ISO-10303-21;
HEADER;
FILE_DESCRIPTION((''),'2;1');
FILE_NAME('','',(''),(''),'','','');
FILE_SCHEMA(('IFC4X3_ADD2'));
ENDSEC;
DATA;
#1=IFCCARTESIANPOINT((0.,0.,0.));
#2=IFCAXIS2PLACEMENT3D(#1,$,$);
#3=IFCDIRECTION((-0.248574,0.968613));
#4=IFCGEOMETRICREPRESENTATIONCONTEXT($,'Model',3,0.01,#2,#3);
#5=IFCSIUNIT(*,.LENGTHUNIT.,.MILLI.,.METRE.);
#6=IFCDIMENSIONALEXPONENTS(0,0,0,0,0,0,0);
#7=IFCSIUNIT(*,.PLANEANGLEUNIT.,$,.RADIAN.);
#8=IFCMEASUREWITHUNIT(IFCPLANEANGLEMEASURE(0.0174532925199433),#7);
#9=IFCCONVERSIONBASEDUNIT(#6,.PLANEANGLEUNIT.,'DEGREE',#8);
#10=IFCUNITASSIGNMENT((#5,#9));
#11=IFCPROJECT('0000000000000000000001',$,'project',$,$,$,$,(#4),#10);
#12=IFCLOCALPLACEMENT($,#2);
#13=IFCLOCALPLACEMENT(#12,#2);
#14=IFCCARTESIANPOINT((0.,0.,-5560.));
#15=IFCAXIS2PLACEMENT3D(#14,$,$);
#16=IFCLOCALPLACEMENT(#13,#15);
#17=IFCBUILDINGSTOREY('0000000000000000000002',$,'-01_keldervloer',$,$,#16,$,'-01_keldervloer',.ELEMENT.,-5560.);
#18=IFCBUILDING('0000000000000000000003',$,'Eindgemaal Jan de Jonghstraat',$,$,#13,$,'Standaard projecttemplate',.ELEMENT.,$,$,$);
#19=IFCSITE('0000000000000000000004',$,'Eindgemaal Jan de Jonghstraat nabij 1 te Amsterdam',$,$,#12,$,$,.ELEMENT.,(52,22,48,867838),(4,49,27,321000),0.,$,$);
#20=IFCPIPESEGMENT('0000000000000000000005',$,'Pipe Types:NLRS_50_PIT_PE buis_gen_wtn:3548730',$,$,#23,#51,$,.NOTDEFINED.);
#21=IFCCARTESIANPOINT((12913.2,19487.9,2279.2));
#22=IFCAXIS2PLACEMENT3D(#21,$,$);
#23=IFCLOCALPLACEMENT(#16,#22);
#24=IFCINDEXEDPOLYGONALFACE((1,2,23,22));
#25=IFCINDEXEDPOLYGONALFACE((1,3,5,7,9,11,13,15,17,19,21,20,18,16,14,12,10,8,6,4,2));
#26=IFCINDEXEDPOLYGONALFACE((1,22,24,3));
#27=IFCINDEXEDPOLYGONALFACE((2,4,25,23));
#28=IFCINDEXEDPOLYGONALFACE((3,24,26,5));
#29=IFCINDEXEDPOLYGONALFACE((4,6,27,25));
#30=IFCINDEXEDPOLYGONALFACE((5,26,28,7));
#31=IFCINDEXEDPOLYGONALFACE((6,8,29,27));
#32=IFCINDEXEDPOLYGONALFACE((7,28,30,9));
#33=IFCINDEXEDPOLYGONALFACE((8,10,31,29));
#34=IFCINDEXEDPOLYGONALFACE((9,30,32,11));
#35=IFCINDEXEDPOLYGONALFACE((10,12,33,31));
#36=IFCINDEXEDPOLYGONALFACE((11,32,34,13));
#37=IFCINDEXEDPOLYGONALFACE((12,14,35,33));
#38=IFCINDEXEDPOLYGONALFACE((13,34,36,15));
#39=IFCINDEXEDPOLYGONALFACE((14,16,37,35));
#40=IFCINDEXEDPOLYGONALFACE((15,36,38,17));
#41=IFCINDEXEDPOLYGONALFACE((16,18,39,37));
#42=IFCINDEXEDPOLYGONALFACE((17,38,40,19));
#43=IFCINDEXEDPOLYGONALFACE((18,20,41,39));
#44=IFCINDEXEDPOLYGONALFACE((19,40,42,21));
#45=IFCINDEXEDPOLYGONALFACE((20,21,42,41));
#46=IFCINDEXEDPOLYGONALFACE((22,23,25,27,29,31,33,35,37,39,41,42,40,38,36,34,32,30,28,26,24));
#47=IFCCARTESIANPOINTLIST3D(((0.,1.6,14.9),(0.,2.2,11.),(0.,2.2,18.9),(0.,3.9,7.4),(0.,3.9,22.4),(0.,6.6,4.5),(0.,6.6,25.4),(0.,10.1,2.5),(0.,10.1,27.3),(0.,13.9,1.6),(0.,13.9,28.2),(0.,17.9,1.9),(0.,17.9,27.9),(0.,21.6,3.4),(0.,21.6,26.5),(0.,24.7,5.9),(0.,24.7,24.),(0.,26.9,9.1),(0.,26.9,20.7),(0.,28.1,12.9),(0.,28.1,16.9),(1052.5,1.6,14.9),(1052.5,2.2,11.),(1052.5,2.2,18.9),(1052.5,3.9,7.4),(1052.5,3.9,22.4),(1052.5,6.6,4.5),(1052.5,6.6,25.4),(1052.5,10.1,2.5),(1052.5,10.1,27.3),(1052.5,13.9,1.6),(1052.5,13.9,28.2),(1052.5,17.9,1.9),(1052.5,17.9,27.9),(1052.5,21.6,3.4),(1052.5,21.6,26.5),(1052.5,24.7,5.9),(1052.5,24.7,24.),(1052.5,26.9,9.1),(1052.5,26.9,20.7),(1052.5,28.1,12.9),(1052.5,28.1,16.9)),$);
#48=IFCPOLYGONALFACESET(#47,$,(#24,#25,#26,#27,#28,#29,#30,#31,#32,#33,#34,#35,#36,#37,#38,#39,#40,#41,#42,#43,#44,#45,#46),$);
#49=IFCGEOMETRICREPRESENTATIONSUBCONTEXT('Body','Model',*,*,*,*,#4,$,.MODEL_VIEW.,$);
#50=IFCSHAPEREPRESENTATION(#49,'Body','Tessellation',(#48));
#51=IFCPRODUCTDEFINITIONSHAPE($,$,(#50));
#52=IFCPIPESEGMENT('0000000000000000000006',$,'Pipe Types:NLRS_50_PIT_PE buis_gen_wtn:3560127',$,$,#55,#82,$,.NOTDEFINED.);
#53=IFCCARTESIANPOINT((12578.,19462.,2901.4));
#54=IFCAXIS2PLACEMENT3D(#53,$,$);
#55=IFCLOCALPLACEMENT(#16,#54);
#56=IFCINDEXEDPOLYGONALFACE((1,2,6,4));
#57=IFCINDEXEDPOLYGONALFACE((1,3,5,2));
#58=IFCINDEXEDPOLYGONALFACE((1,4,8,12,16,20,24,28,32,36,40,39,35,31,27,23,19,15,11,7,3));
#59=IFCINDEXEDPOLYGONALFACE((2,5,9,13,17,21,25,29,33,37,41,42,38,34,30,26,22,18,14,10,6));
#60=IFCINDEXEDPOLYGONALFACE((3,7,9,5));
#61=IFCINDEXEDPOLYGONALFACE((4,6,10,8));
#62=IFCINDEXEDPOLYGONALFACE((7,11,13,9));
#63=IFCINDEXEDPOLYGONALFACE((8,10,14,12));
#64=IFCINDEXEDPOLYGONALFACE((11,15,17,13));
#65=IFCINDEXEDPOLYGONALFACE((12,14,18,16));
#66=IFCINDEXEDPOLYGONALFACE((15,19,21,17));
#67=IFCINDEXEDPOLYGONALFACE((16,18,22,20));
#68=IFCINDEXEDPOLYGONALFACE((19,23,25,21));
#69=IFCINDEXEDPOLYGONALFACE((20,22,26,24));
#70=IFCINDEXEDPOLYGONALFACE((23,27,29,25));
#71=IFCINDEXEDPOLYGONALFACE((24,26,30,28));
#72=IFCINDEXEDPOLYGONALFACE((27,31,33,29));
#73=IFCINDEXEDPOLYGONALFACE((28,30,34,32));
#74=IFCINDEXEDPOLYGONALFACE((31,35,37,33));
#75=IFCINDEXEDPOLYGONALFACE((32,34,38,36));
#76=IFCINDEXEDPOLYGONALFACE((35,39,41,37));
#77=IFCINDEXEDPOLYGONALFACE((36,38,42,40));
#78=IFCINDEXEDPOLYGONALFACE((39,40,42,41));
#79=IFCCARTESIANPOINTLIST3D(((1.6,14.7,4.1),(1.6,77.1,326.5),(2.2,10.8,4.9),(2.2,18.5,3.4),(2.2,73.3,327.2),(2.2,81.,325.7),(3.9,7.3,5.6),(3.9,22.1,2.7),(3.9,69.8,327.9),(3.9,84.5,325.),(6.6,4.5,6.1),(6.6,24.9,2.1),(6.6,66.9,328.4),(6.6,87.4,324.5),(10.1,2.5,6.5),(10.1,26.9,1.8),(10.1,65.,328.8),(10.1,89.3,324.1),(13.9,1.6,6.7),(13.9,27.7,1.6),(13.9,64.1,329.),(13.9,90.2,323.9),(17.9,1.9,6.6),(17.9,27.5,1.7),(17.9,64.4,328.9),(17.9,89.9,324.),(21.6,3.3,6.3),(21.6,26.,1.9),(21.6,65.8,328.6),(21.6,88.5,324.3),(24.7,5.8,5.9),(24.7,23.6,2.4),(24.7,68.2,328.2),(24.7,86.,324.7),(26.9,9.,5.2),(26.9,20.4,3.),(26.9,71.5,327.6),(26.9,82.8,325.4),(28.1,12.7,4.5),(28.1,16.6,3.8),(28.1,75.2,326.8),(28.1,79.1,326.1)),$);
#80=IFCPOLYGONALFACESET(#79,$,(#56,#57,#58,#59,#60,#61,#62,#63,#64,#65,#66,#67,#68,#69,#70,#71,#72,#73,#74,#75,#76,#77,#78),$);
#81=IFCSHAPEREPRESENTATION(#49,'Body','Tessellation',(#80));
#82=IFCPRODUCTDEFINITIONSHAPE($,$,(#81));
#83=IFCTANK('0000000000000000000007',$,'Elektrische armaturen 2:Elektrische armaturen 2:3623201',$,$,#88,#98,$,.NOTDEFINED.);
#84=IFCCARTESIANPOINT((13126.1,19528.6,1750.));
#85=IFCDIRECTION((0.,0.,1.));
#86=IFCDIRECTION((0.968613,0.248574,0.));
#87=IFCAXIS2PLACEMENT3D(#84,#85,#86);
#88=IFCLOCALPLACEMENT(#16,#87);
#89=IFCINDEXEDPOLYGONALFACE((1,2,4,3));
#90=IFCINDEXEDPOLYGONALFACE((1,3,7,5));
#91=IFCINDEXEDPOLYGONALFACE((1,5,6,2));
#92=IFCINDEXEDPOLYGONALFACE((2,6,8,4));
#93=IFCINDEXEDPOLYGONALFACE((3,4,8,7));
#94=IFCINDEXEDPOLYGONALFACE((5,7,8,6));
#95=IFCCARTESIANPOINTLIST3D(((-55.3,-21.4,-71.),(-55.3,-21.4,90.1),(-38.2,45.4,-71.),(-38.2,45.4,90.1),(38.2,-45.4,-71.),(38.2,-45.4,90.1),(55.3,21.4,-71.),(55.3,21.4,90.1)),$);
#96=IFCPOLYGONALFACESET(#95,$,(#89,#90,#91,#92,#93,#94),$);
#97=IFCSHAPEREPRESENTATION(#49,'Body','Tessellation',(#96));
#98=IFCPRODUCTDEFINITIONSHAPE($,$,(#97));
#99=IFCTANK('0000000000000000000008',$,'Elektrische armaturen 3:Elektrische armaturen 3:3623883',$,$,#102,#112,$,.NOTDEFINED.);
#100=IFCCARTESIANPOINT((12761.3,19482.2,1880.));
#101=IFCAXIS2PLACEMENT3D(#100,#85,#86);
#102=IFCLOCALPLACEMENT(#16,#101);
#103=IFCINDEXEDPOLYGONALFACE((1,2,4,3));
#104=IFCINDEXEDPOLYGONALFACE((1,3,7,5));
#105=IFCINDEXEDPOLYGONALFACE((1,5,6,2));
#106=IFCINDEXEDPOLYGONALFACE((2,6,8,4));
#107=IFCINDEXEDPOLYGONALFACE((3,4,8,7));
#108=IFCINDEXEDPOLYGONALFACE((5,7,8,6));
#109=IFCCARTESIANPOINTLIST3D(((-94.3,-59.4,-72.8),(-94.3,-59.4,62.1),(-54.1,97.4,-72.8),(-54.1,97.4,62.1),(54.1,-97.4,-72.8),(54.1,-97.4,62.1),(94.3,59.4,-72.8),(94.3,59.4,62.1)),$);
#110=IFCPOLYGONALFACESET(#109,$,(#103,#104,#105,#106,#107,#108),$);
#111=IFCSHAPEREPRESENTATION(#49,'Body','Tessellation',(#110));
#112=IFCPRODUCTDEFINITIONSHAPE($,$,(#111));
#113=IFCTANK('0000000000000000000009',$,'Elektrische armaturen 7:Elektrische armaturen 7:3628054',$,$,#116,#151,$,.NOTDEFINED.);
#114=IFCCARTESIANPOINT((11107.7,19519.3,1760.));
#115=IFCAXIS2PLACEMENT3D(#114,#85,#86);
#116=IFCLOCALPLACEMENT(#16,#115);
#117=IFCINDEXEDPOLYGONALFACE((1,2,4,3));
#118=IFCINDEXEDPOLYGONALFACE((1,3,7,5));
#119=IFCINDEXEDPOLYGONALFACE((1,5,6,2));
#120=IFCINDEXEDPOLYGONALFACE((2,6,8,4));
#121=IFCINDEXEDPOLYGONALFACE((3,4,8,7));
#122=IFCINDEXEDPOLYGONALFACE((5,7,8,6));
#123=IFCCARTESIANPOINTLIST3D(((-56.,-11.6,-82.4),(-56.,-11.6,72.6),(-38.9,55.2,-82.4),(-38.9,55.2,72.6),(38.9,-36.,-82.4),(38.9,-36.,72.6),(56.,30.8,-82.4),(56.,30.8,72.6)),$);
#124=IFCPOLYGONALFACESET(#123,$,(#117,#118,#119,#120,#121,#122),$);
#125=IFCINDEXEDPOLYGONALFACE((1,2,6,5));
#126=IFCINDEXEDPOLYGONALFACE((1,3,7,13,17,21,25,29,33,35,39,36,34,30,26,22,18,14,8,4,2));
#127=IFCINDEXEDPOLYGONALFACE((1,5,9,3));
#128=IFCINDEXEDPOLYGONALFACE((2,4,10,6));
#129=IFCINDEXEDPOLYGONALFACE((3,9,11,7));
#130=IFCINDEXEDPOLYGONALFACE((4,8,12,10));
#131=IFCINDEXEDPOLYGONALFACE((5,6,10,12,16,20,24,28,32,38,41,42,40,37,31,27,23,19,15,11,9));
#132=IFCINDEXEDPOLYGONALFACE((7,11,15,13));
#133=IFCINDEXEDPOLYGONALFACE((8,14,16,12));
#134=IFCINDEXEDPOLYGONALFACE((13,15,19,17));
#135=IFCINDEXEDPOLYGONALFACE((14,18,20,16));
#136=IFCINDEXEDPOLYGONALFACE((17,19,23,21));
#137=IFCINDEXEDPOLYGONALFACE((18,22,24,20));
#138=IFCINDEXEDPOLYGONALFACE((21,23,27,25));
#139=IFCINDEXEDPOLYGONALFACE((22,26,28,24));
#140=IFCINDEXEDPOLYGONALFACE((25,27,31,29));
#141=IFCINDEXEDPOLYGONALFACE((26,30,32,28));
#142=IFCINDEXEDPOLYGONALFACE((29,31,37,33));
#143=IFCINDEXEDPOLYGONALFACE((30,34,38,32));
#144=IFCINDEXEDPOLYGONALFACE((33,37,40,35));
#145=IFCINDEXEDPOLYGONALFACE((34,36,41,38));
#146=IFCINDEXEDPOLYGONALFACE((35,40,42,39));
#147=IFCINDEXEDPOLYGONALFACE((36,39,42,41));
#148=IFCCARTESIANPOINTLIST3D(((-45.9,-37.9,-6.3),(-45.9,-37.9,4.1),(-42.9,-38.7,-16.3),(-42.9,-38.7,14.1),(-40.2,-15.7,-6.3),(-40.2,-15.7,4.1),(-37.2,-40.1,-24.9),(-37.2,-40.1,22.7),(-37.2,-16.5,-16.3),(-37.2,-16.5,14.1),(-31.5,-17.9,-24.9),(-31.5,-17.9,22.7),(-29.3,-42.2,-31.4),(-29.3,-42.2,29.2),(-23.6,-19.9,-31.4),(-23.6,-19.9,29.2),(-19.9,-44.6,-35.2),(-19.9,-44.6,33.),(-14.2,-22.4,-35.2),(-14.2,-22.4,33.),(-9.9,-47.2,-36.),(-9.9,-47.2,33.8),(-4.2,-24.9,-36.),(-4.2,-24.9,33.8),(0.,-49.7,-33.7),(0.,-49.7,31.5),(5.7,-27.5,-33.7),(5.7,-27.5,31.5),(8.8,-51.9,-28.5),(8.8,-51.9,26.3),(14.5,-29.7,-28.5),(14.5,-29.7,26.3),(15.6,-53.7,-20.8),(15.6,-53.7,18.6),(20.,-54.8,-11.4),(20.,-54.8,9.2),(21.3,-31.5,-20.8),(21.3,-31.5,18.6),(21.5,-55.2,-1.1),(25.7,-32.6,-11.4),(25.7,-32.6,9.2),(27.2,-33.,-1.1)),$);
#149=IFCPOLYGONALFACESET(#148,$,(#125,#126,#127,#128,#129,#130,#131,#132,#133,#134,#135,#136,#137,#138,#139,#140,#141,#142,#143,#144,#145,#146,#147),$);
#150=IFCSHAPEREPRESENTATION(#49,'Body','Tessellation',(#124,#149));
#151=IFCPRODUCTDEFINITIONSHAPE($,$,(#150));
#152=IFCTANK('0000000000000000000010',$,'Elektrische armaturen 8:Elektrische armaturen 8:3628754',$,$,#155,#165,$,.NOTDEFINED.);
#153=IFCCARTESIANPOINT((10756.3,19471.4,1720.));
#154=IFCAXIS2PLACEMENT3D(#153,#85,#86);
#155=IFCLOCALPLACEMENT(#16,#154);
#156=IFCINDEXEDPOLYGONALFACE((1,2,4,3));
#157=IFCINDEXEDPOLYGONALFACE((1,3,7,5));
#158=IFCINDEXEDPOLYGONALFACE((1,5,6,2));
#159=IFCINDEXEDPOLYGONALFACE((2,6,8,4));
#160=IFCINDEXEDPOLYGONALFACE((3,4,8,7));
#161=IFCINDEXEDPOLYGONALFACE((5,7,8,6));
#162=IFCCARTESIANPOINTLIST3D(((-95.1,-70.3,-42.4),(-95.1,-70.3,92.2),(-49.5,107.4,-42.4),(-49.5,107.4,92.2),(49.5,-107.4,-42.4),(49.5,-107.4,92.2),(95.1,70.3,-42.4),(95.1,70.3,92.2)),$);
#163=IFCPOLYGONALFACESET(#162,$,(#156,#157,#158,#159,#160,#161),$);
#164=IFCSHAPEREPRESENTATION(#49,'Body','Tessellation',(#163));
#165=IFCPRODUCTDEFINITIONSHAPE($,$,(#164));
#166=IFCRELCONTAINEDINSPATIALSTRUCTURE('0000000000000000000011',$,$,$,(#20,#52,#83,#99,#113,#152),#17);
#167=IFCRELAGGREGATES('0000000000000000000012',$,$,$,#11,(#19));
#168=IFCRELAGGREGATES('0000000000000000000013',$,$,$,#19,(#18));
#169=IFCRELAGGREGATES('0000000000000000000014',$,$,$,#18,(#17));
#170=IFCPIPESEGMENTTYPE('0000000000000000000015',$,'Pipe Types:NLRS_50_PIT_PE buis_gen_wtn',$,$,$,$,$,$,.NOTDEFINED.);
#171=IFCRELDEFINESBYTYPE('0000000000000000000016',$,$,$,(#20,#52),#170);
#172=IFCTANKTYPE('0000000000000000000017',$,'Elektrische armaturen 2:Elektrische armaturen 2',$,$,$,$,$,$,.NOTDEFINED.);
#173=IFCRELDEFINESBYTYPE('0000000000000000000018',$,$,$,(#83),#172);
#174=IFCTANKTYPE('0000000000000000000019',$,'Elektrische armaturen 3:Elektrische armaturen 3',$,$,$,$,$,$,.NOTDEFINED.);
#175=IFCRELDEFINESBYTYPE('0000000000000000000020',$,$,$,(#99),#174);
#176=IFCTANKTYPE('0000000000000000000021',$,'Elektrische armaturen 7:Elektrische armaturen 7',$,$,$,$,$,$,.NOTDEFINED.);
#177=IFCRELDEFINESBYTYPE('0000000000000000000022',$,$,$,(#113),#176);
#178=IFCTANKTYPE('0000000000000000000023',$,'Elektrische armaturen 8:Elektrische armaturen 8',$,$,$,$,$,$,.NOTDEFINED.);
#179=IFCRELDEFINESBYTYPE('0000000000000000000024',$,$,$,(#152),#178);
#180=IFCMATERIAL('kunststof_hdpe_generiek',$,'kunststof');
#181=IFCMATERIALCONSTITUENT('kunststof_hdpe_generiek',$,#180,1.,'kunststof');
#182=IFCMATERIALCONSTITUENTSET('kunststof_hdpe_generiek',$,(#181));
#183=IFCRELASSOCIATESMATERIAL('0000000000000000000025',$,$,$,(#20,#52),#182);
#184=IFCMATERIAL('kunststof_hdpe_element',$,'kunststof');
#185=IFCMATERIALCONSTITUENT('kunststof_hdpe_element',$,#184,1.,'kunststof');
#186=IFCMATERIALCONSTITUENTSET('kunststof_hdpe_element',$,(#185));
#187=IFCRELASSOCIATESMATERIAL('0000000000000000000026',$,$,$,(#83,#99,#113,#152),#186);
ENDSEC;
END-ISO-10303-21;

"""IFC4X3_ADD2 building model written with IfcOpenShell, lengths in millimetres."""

from ifc_helpers import new_model, entity, si_unit, converted_unit, direction, frame, frame_2d, origin, origin_2d_with_axis, place, context, subcontext, project, spatial, rectangle, circle, extrude, source, transform, mapped, material, constituent, constituent_set, type_object, type_shapes, element, save


model = new_model("IFC4X3_ADD2")

# Units and contexts
model_context = context("Model", 3, precision=0.01, world=origin(), true_north=direction((-0.248574, 0.968613)))
body_context = subcontext(model_context, "Body", "Model", "MODEL_VIEW")
ifc_project = project(units=[si_unit("LENGTHUNIT", "METRE", prefix="MILLI"), converted_unit("PLANEANGLEUNIT", "DEGREE", entity("IfcPlaneAngleMeasure", 0.0174532925199433), si_unit("PLANEANGLEUNIT", "RADIAN"), dimensions=[0, 0, 0, 0, 0, 0, 0])], contexts=[model_context])

# Site, building, storey
site_placement = place(None, origin())
site = spatial("IfcSite", under=ifc_project, at=site_placement, Name="Eindgemaal Jan de Jonghstraat nabij 1 te Amsterdam", CompositionType="ELEMENT", RefLatitude=(52, 22, 48, 867838), RefLongitude=(4, 49, 27, 321000), RefElevation=0.0)
building_placement = place(site_placement, origin())
building = spatial("IfcBuilding", under=site, at=building_placement, Name="Eindgemaal Jan de Jonghstraat", LongName="Standaard projecttemplate", CompositionType="ELEMENT")
storey_placement = place(building_placement, frame((0.0, 0.0, -5560.0)))
storey = spatial("IfcBuildingStorey", under=building, at=storey_placement, Name="-01_keldervloer", LongName="-01_keldervloer", CompositionType="ELEMENT", Elevation=-5560.0)

# Pipe segments
ifc_material_1 = material(Name="kunststof_hdpe_generiek", Category="kunststof")
ifc_constituent_1 = constituent(ifc_material_1, Name="kunststof_hdpe_generiek", Category="kunststof", fraction=1.0)
ifc_constituent_set_1 = constituent_set(constituents=[ifc_constituent_1], Name="kunststof_hdpe_generiek")
pipe_segment_type_1 = type_object("IfcPipeSegmentType", Name="Pipe Types:NLRS_50_PIT_PE buis_gen_wtn", PredefinedType="NOTDEFINED")
pipe_segment_1_placement = place(storey_placement, frame((12913.2, 19487.9, 2279.2)))
element("IfcPipeSegment", 1, at=pipe_segment_1_placement, inside=storey, type_object=pipe_segment_type_1, material=ifc_constituent_set_1, Name="Pipe Types:NLRS_50_PIT_PE buis_gen_wtn:3548730", PredefinedType="NOTDEFINED", context=body_context, shape_type="SweptSolid", body=[
    extrude(circle(Radius=13.3, at=origin_2d_with_axis()), frame((0.0, 14.9, 14.9), z_axis=(1.0, 0.0, 0.0), x_axis=(0.0, -1.0, 0.0)), (0.0, 0.0, 1.0), 1052.5),
])
pipe_segment_2_placement = place(storey_placement, frame((12578.0, 19462.0, 2901.4)))
element("IfcPipeSegment", 2, at=pipe_segment_2_placement, inside=storey, type_object=pipe_segment_type_1, material=ifc_constituent_set_1, Name="Pipe Types:NLRS_50_PIT_PE buis_gen_wtn:3560127", PredefinedType="NOTDEFINED", context=body_context, shape_type="SweptSolid", body=[
    extrude(circle(Radius=13.3, at=frame_2d((0.0, 0.0), x_axis=(1.0, 0.0))), frame((14.9, 14.7, 4.1), z_axis=(0.0, 0.190233, 0.981739), x_axis=(-1.0, 0.0, 0.0)), (0.0, 0.0, 1.0), 328.3),
])

# Tanks
ifc_material_2 = material(Name="kunststof_hdpe_element", Category="kunststof")
ifc_constituent_2 = constituent(ifc_material_2, Name="kunststof_hdpe_element", Category="kunststof", fraction=1.0)
ifc_constituent_set_2 = constituent_set(constituents=[ifc_constituent_2], Name="kunststof_hdpe_element")
tank_type_1 = type_object("IfcTankType", Name="Elektrische armaturen 2:Elektrische armaturen 2", PredefinedType="NOTDEFINED")
shared_shape_1 = source(origin(), body_context, "Body", "SweptSolid", [
    extrude(rectangle(XDim=69.0, YDim=96.6, at=origin_2d_with_axis()), frame((0.0, 0.0, -71.0), z_axis=(0.0, 0.0, 1.0), x_axis=(0.248574, 0.968613, 0.0)), (0.0, 0.0, 1.0), 161.1),
])
type_shapes(tank_type_1, [shared_shape_1])
tank_1_placement = place(storey_placement, frame((13126.1, 19528.6, 1750.0), z_axis=(0.0, 0.0, 1.0), x_axis=(0.968613, 0.248574, 0.0)))
element("IfcTank", 3, at=tank_1_placement, inside=storey, type_object=tank_type_1, material=ifc_constituent_set_2, Name="Elektrische armaturen 2:Elektrische armaturen 2:3623201", PredefinedType="NOTDEFINED", context=body_context, shape_type="MappedRepresentation", body=[
    mapped(shared_shape_1, transform((0.0, 0.0, 0.0), scale=1.0)),
])
tank_type_2 = type_object("IfcTankType", Name="Elektrische armaturen 3:Elektrische armaturen 3", PredefinedType="NOTDEFINED")
shared_shape_2 = source(origin(), body_context, "Body", "SweptSolid", [
    extrude(rectangle(XDim=161.9, YDim=153.2, at=origin_2d_with_axis()), frame((0.0, 0.0, -72.8), z_axis=(0.0, 0.0, 1.0), x_axis=(0.248574, 0.968613, 0.0)), (0.0, 0.0, 1.0), 134.9),
])
type_shapes(tank_type_2, [shared_shape_2])
tank_2_placement = place(storey_placement, frame((12761.3, 19482.2, 1880.0), z_axis=(0.0, 0.0, 1.0), x_axis=(0.968613, 0.248574, 0.0)))
element("IfcTank", 4, at=tank_2_placement, inside=storey, type_object=tank_type_2, material=ifc_constituent_set_2, Name="Elektrische armaturen 3:Elektrische armaturen 3:3623883", PredefinedType="NOTDEFINED", context=body_context, shape_type="MappedRepresentation", body=[
    mapped(shared_shape_2, transform((0.0, 0.0, 0.0), scale=1.0)),
])
tank_type_3 = type_object("IfcTankType", Name="Elektrische armaturen 7:Elektrische armaturen 7", PredefinedType="NOTDEFINED")
shared_shape_3 = source(origin(), body_context, "Body", "SweptSolid", [
    extrude(rectangle(XDim=69.0, YDim=98.0, at=frame_2d((0.0, 0.0), x_axis=(1.0, 0.0))), frame((0.0, 9.6, -82.4), z_axis=(0.0, 0.0, 1.0), x_axis=(0.248574, 0.968613, 0.0)), (0.0, 0.0, 1.0), 155.0),
    extrude(circle(Radius=35.0, at=frame_2d((0.0, 0.0), x_axis=(1.0, 0.0))), frame((-12.4, -46.5, -1.1), z_axis=(0.248574, 0.968613, 0.0), x_axis=(0.968613, -0.248574, 0.0)), (0.0, 0.0, 1.0), 22.9),
])
type_shapes(tank_type_3, [shared_shape_3])
tank_3_placement = place(storey_placement, frame((11107.7, 19519.3, 1760.0), z_axis=(0.0, 0.0, 1.0), x_axis=(0.968613, 0.248574, 0.0)))
element("IfcTank", 5, at=tank_3_placement, inside=storey, type_object=tank_type_3, material=ifc_constituent_set_2, Name="Elektrische armaturen 7:Elektrische armaturen 7:3628054", PredefinedType="NOTDEFINED", context=body_context, shape_type="MappedRepresentation", body=[
    mapped(shared_shape_3, transform((0.0, 0.0, 0.0), scale=1.0)),
])
tank_type_4 = type_object("IfcTankType", Name="Elektrische armaturen 8:Elektrische armaturen 8", PredefinedType="NOTDEFINED")
shared_shape_4 = source(origin(), body_context, "Body", "SweptSolid", [
    extrude(rectangle(XDim=183.4, YDim=149.4, at=frame_2d((0.0, 0.0), x_axis=(1.0, 0.0))), frame((0.0, 0.0, -42.4), z_axis=(0.0, 0.0, 1.0), x_axis=(0.248574, 0.968613, 0.0)), (0.0, 0.0, 1.0), 134.6),
])
type_shapes(tank_type_4, [shared_shape_4])
tank_4_placement = place(storey_placement, frame((10756.3, 19471.4, 1720.0), z_axis=(0.0, 0.0, 1.0), x_axis=(0.968613, 0.248574, 0.0)))
element("IfcTank", 6, at=tank_4_placement, inside=storey, type_object=tank_type_4, material=ifc_constituent_set_2, Name="Elektrische armaturen 8:Elektrische armaturen 8:3628754", PredefinedType="NOTDEFINED", context=body_context, shape_type="MappedRepresentation", body=[
    mapped(shared_shape_4, transform((0.0, 0.0, 0.0), scale=1.0)),
])

save(model, "model.ifc")
